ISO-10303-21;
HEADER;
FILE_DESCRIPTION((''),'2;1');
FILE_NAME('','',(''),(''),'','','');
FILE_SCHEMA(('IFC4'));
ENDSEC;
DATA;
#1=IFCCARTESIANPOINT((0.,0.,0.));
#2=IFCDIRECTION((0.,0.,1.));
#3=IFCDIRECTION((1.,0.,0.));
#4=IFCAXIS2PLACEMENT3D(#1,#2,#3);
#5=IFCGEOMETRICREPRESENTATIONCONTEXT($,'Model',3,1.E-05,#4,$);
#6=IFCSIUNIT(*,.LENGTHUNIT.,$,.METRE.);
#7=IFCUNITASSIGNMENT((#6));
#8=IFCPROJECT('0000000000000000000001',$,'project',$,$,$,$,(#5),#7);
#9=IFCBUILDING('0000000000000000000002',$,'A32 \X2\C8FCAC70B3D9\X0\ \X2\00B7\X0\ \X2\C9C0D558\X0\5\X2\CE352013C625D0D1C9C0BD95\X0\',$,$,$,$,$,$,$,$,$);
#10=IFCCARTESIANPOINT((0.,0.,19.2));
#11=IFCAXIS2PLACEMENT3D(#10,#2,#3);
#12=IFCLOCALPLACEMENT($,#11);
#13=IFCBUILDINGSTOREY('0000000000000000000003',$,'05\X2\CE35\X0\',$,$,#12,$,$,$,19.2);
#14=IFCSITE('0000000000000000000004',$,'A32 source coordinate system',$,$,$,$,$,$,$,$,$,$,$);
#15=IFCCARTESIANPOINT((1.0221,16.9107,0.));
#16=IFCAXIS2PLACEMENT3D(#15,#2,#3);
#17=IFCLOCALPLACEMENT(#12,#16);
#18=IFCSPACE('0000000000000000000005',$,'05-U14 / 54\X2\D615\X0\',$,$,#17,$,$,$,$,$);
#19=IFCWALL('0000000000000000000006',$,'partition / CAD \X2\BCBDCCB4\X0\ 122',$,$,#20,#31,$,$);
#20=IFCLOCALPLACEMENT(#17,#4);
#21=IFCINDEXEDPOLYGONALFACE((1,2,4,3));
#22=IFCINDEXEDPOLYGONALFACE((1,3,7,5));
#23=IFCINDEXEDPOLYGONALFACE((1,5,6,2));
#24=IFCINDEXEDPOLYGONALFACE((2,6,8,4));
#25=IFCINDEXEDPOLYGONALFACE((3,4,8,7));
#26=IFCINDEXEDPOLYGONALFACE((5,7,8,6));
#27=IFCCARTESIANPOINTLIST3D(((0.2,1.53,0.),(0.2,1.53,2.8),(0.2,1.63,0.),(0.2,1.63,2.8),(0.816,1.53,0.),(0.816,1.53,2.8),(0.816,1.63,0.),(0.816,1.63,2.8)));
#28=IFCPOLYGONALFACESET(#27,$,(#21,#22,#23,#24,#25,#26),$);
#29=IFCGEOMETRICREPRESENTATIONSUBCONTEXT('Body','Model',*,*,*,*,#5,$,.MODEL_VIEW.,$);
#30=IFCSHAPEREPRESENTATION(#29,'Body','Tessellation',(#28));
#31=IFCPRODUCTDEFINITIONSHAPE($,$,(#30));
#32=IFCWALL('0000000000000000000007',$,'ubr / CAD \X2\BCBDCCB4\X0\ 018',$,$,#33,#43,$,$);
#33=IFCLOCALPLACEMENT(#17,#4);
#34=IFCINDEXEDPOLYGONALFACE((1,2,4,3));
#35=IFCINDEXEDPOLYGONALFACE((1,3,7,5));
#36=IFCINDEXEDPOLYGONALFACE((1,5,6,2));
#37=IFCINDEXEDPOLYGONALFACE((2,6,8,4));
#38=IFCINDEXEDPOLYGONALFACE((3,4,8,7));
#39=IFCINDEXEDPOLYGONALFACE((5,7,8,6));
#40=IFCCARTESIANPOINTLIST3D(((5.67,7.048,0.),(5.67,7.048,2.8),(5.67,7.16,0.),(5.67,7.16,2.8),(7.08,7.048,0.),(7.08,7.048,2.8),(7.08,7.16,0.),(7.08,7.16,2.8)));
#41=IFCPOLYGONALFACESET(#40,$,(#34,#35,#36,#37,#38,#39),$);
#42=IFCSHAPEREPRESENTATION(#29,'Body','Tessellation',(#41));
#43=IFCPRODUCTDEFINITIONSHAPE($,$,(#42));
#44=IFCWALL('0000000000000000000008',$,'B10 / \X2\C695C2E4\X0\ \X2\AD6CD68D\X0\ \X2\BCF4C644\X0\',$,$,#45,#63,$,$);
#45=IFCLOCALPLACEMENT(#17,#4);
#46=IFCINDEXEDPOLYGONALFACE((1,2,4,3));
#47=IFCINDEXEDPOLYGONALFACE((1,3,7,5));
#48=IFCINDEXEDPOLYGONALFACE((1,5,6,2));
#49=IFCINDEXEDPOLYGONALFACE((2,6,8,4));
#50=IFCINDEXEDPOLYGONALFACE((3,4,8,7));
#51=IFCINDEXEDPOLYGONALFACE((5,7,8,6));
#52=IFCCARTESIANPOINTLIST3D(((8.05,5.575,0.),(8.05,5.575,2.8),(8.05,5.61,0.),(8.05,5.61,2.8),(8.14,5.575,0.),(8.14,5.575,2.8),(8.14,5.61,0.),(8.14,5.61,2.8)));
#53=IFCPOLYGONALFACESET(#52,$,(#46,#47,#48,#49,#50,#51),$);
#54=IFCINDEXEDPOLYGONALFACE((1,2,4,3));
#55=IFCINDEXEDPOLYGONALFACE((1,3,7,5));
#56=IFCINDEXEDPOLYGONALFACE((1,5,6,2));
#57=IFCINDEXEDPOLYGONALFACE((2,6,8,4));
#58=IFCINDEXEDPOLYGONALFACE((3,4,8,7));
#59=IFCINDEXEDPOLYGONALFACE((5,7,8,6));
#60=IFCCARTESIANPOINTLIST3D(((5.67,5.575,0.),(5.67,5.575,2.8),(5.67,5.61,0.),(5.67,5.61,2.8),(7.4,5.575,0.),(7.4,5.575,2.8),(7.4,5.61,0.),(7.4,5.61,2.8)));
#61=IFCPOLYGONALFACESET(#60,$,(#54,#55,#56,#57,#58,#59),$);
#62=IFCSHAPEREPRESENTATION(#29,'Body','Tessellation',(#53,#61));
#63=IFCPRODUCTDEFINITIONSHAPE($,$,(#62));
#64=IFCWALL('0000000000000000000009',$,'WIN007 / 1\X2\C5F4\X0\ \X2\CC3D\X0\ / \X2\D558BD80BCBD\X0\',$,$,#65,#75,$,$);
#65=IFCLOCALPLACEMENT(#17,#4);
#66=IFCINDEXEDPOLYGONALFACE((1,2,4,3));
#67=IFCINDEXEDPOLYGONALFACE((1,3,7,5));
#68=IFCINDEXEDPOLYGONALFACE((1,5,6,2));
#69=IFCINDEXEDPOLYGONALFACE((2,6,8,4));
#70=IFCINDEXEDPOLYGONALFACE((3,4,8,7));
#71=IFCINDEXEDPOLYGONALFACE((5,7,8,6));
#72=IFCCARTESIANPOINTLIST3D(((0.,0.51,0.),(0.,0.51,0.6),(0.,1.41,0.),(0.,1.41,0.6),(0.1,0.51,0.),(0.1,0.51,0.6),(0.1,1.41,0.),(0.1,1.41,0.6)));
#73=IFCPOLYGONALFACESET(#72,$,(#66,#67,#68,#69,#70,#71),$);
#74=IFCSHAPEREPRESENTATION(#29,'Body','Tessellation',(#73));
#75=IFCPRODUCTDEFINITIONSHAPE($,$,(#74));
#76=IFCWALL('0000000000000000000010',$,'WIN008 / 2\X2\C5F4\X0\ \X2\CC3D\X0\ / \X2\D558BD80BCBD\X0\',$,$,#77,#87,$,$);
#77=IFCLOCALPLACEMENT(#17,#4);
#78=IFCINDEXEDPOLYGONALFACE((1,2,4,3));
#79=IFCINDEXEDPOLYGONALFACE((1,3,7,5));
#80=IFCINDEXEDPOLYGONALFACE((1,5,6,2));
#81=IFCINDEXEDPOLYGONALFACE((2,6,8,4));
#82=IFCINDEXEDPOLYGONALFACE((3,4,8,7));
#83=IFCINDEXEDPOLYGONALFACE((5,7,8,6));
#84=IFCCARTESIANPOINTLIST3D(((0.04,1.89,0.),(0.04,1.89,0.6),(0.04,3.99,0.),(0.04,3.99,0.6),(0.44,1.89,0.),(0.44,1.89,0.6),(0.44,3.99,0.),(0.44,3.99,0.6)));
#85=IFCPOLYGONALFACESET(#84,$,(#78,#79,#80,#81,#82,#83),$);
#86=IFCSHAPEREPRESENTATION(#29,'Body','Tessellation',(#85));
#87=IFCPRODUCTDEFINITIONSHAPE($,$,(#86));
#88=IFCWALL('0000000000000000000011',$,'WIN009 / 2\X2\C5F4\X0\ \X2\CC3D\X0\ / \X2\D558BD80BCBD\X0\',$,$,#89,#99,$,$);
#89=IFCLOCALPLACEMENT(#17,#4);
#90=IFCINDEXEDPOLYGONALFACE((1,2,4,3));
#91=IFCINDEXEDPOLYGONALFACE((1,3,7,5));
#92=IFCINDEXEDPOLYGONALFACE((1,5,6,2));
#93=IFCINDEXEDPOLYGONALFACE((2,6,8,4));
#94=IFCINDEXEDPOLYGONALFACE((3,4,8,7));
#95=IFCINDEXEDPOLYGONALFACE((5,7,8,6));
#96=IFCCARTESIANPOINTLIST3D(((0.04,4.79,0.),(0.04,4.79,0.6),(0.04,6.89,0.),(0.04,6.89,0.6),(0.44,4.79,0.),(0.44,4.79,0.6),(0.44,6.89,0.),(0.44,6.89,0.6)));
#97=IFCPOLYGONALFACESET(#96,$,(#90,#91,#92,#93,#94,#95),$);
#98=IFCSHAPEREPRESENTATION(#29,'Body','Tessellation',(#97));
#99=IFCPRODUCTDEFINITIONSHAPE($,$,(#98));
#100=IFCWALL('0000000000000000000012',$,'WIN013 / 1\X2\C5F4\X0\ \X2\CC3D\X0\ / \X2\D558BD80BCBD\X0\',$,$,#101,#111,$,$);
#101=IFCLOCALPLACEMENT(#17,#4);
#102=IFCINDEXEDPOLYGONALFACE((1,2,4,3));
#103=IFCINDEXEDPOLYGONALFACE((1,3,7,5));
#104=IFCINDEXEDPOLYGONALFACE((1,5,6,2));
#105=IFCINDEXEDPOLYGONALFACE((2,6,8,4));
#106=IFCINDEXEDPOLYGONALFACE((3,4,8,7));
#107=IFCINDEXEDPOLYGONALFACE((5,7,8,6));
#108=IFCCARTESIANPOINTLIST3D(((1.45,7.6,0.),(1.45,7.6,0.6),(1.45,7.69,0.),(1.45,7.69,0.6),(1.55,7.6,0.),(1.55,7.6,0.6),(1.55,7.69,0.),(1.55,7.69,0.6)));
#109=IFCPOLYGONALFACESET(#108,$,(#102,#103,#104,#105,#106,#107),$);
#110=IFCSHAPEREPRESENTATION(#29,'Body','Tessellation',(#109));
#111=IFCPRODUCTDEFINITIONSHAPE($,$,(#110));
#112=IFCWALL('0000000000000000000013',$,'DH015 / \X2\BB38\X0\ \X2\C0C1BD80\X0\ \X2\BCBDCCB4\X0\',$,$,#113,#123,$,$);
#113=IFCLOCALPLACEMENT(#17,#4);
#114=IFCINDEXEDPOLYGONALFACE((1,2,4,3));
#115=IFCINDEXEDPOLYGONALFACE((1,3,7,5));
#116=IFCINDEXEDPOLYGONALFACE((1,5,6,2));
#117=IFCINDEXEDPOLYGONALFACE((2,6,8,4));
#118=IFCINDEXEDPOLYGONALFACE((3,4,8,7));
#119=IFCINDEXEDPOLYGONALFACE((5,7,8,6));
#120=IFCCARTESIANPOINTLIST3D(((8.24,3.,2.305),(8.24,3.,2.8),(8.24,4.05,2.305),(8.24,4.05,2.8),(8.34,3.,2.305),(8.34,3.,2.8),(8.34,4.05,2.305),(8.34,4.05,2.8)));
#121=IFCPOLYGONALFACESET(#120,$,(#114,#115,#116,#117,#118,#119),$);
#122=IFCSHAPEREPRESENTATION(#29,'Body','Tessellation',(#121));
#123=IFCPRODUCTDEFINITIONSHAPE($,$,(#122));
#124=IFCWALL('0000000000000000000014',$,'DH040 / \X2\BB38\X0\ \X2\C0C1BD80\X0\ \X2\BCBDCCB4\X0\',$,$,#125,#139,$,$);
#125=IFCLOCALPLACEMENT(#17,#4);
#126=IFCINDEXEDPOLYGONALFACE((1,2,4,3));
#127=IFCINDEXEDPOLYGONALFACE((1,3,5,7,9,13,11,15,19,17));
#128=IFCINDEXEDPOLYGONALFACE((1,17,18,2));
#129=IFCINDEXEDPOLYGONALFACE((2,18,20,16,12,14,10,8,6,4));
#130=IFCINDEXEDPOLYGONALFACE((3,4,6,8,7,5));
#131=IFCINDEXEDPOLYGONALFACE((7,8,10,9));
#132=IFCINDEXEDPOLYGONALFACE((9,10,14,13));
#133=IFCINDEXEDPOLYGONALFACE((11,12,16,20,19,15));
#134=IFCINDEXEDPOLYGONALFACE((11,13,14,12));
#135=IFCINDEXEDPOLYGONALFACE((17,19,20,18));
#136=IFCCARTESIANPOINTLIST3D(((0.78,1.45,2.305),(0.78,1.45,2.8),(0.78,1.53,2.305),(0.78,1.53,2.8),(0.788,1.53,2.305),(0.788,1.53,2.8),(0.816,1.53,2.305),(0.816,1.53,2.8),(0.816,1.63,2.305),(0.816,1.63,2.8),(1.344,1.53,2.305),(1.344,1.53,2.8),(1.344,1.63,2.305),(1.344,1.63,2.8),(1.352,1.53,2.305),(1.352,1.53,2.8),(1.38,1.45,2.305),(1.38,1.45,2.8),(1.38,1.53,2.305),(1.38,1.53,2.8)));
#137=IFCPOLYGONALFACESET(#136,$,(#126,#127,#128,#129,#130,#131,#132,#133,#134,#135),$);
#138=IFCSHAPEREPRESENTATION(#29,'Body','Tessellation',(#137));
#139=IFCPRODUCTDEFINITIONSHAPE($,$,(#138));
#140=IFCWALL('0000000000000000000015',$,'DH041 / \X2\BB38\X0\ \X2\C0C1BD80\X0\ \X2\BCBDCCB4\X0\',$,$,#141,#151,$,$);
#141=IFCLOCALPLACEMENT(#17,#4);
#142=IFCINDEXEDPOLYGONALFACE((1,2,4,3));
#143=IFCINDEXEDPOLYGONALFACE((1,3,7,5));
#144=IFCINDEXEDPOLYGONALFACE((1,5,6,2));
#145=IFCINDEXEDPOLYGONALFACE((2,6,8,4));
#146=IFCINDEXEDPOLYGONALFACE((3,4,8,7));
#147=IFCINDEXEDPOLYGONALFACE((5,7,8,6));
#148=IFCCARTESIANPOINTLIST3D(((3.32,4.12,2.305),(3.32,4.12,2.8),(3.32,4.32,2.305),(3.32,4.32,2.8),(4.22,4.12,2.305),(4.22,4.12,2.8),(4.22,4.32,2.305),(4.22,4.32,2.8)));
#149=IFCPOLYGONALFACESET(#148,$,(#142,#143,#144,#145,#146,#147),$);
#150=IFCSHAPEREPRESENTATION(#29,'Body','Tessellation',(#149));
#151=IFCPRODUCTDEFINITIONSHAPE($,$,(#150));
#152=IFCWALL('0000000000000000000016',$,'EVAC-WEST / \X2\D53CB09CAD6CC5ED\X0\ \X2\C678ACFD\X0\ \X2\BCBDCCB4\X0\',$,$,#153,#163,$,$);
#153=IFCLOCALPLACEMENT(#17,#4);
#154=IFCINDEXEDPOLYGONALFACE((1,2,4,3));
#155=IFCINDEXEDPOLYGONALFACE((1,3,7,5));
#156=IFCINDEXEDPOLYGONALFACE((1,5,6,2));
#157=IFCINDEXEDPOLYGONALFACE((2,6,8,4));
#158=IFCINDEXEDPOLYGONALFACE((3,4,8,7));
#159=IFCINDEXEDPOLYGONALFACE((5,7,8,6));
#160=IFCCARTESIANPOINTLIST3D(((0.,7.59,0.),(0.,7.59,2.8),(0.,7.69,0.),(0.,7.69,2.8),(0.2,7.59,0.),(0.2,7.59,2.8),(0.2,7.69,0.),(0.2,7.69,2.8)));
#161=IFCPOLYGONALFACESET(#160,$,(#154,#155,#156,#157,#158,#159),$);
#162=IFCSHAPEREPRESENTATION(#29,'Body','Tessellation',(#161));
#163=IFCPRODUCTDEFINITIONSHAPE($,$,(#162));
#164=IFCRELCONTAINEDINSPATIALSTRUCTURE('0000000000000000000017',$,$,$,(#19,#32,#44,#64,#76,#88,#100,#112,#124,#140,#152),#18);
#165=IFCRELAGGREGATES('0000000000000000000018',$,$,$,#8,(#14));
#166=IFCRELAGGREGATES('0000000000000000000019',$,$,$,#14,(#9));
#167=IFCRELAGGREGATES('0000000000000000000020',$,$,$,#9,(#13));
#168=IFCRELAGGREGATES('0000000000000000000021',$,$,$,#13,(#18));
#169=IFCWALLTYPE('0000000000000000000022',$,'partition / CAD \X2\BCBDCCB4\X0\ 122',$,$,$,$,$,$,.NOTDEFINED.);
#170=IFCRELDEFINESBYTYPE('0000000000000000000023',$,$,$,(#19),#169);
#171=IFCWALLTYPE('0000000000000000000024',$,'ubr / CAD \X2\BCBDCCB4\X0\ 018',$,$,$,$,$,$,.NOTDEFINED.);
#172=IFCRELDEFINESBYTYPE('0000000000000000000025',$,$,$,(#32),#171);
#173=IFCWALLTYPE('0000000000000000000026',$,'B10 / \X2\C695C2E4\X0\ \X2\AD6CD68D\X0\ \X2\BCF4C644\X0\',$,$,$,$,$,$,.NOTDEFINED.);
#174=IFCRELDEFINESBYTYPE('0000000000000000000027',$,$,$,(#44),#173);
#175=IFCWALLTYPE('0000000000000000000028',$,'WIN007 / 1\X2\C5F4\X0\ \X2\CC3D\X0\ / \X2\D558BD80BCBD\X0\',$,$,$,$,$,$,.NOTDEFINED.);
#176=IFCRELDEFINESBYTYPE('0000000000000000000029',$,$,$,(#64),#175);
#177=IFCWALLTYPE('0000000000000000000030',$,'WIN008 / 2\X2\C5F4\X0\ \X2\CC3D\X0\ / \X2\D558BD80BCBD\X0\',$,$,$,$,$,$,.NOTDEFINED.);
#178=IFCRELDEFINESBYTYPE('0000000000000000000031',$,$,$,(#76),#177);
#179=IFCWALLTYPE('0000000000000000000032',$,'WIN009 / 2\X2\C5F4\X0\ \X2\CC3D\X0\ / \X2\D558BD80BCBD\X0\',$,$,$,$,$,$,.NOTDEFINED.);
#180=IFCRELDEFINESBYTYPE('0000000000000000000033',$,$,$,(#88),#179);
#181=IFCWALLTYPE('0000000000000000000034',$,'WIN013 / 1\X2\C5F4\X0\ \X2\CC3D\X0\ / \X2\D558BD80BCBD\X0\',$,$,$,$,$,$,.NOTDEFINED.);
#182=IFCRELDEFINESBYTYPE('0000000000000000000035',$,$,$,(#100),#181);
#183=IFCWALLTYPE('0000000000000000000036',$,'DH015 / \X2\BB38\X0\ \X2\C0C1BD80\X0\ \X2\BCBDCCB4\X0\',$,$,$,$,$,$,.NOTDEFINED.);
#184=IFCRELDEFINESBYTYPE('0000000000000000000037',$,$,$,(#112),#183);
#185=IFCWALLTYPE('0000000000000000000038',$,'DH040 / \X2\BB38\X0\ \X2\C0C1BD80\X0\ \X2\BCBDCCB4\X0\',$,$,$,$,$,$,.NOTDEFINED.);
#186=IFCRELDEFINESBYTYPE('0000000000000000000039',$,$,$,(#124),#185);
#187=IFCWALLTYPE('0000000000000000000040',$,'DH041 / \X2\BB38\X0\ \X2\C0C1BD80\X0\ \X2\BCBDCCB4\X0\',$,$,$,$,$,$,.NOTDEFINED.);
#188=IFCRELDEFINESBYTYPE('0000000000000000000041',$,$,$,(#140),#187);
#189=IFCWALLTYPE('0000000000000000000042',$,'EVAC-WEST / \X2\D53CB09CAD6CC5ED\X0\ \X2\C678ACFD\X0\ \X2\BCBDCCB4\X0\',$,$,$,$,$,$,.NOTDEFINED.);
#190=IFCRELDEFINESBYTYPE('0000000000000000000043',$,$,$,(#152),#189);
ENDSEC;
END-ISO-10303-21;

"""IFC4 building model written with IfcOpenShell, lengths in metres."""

from ifc_helpers import new_model, si_unit, frame, origin, origin_with_axes, place, context, subcontext, project, spatial, polyline, outline, extrude, source, transform, mapped, type_object, type_shapes, element, save


model = new_model("IFC4")

# Units and contexts
model_context = context("Model", 3, precision=1e-05, world=origin_with_axes())
body_context = subcontext(model_context, "Body", "Model", "MODEL_VIEW")
ifc_project = project(units=[si_unit("LENGTHUNIT", "METRE")], contexts=[model_context])

# Site, building, storey, space
site = spatial("IfcSite", under=ifc_project, Name="A32 source coordinate system")
building = spatial("IfcBuilding", under=site, Name="A32 주거동 · 지하5층–옥탑지붕")
storey_placement = place(None, frame((0.0, 0.0, 19.2), z_axis=(0.0, 0.0, 1.0), x_axis=(1.0, 0.0, 0.0)))
storey = spatial("IfcBuildingStorey", under=building, at=storey_placement, Name="05층", Elevation=19.2)
space_placement = place(storey_placement, frame((1.0221, 16.9107, 0.0), z_axis=(0.0, 0.0, 1.0), x_axis=(1.0, 0.0, 0.0)))
space = spatial("IfcSpace", under=storey, at=space_placement, Name="05-U14 / 54형")

# Walls
wall_type_1 = type_object("IfcWallType", Name="partition / CAD 벽체 122", PredefinedType="NOTDEFINED")
shared_shape_1 = source(origin(), body_context, "Body", "SweptSolid", [
    extrude(outline(polyline([(0.816, 1.63), (0.816, 1.53), (0.2, 1.53), (0.2, 1.63), (0.816, 1.63)])), origin(), (0.0, 0.0, 1.0), 2.8),
])
type_shapes(wall_type_1, [shared_shape_1])
wall_1_placement = place(space_placement, origin_with_axes())
element("IfcWall", 1, at=wall_1_placement, inside=space, type_object=wall_type_1, Name="partition / CAD 벽체 122", context=body_context, shape_type="MappedRepresentation", body=[
    mapped(shared_shape_1, transform((0.0, 0.0, 0.0), scale=1.0)),
])
wall_type_2 = type_object("IfcWallType", Name="ubr / CAD 벽체 018", PredefinedType="NOTDEFINED")
shared_shape_2 = source(origin(), body_context, "Body", "SweptSolid", [
    extrude(outline(polyline([(5.67, 7.16), (7.08, 7.16), (7.08, 7.048), (5.67, 7.048), (5.67, 7.16)])), origin(), (0.0, 0.0, 1.0), 2.8),
])
type_shapes(wall_type_2, [shared_shape_2])
wall_2_placement = place(space_placement, origin_with_axes())
element("IfcWall", 2, at=wall_2_placement, inside=space, type_object=wall_type_2, Name="ubr / CAD 벽체 018", context=body_context, shape_type="MappedRepresentation", body=[
    mapped(shared_shape_2, transform((0.0, 0.0, 0.0), scale=1.0)),
])
wall_type_3 = type_object("IfcWallType", Name="B10 / 욕실 구획 보완", PredefinedType="NOTDEFINED")
shared_shape_3 = source(origin(), body_context, "Body", "SweptSolid", [
    extrude(outline(polyline([(8.14, 5.575), (8.05, 5.575), (8.05, 5.61), (8.14, 5.61), (8.14, 5.575)])), origin(), (0.0, 0.0, 1.0), 2.8),
    extrude(outline(polyline([(7.4, 5.575), (5.67, 5.575), (5.67, 5.61), (7.4, 5.61), (7.4, 5.575)])), origin(), (0.0, 0.0, 1.0), 2.8),
])
type_shapes(wall_type_3, [shared_shape_3])
wall_3_placement = place(space_placement, origin_with_axes())
element("IfcWall", 3, at=wall_3_placement, inside=space, type_object=wall_type_3, Name="B10 / 욕실 구획 보완", context=body_context, shape_type="MappedRepresentation", body=[
    mapped(shared_shape_3, transform((0.0, 0.0, 0.0), scale=1.0)),
])
wall_type_4 = type_object("IfcWallType", Name="WIN007 / 1열 창 / 하부벽", PredefinedType="NOTDEFINED")
shared_shape_4 = source(origin(), body_context, "Body", "SweptSolid", [
    extrude(outline(polyline([(0.1, 1.41), (0.1, 0.51), (0.0, 0.51), (0.0, 1.41), (0.1, 1.41)])), origin(), (0.0, 0.0, 1.0), 0.6),
])
type_shapes(wall_type_4, [shared_shape_4])
wall_4_placement = place(space_placement, origin_with_axes())
element("IfcWall", 4, at=wall_4_placement, inside=space, type_object=wall_type_4, Name="WIN007 / 1열 창 / 하부벽", context=body_context, shape_type="MappedRepresentation", body=[
    mapped(shared_shape_4, transform((0.0, 0.0, 0.0), scale=1.0)),
])
wall_type_5 = type_object("IfcWallType", Name="WIN008 / 2열 창 / 하부벽", PredefinedType="NOTDEFINED")
shared_shape_5 = source(origin(), body_context, "Body", "SweptSolid", [
    extrude(outline(polyline([(0.44, 3.99), (0.44, 1.89), (0.04, 1.89), (0.04, 3.99), (0.44, 3.99)])), origin(), (0.0, 0.0, 1.0), 0.6),
])
type_shapes(wall_type_5, [shared_shape_5])
wall_5_placement = place(space_placement, origin_with_axes())
element("IfcWall", 5, at=wall_5_placement, inside=space, type_object=wall_type_5, Name="WIN008 / 2열 창 / 하부벽", context=body_context, shape_type="MappedRepresentation", body=[
    mapped(shared_shape_5, transform((0.0, 0.0, 0.0), scale=1.0)),
])
wall_type_6 = type_object("IfcWallType", Name="WIN009 / 2열 창 / 하부벽", PredefinedType="NOTDEFINED")
shared_shape_6 = source(origin(), body_context, "Body", "SweptSolid", [
    extrude(outline(polyline([(0.44, 6.89), (0.44, 4.79), (0.04, 4.79), (0.04, 6.89), (0.44, 6.89)])), origin(), (0.0, 0.0, 1.0), 0.6),
])
type_shapes(wall_type_6, [shared_shape_6])
wall_6_placement = place(space_placement, origin_with_axes())
element("IfcWall", 6, at=wall_6_placement, inside=space, type_object=wall_type_6, Name="WIN009 / 2열 창 / 하부벽", context=body_context, shape_type="MappedRepresentation", body=[
    mapped(shared_shape_6, transform((0.0, 0.0, 0.0), scale=1.0)),
])
wall_type_7 = type_object("IfcWallType", Name="WIN013 / 1열 창 / 하부벽", PredefinedType="NOTDEFINED")
shared_shape_7 = source(origin(), body_context, "Body", "SweptSolid", [
    extrude(outline(polyline([(1.55, 7.6), (1.45, 7.6), (1.45, 7.69), (1.55, 7.69), (1.55, 7.6)])), origin(), (0.0, 0.0, 1.0), 0.6),
])
type_shapes(wall_type_7, [shared_shape_7])
wall_7_placement = place(space_placement, origin_with_axes())
element("IfcWall", 7, at=wall_7_placement, inside=space, type_object=wall_type_7, Name="WIN013 / 1열 창 / 하부벽", context=body_context, shape_type="MappedRepresentation", body=[
    mapped(shared_shape_7, transform((0.0, 0.0, 0.0), scale=1.0)),
])
wall_type_8 = type_object("IfcWallType", Name="DH015 / 문 상부 벽체", PredefinedType="NOTDEFINED")
shared_shape_8 = source(origin(), body_context, "Body", "SweptSolid", [
    extrude(outline(polyline([(8.34, 3.0), (8.24, 3.0), (8.24, 4.05), (8.34, 4.05), (8.34, 3.0)])), frame((0.0, 0.0, 2.305)), (0.0, 0.0, 1.0), 0.495),
])
type_shapes(wall_type_8, [shared_shape_8])
wall_8_placement = place(space_placement, origin_with_axes())
element("IfcWall", 8, at=wall_8_placement, inside=space, type_object=wall_type_8, Name="DH015 / 문 상부 벽체", context=body_context, shape_type="MappedRepresentation", body=[
    mapped(shared_shape_8, transform((0.0, 0.0, 0.0), scale=1.0)),
])
wall_type_9 = type_object("IfcWallType", Name="DH040 / 문 상부 벽체", PredefinedType="NOTDEFINED")
shared_shape_9 = source(origin(), body_context, "Body", "SweptSolid", [
    extrude(outline(polyline([(0.816, 1.63), (1.344, 1.63), (1.344, 1.53), (1.352, 1.53), (1.38, 1.53), (1.38, 1.45), (0.78, 1.45), (0.78, 1.53), (0.788, 1.53), (0.816, 1.53), (0.816, 1.63)])), frame((0.0, 0.0, 2.305)), (0.0, 0.0, 1.0), 0.495),
])
type_shapes(wall_type_9, [shared_shape_9])
wall_9_placement = place(space_placement, origin_with_axes())
element("IfcWall", 9, at=wall_9_placement, inside=space, type_object=wall_type_9, Name="DH040 / 문 상부 벽체", context=body_context, shape_type="MappedRepresentation", body=[
    mapped(shared_shape_9, transform((0.0, 0.0, 0.0), scale=1.0)),
])
wall_type_10 = type_object("IfcWallType", Name="DH041 / 문 상부 벽체", PredefinedType="NOTDEFINED")
shared_shape_10 = source(origin(), body_context, "Body", "SweptSolid", [
    extrude(outline(polyline([(4.22, 4.12), (3.32, 4.12), (3.32, 4.32), (4.22, 4.32), (4.22, 4.12)])), frame((0.0, 0.0, 2.305)), (0.0, 0.0, 1.0), 0.495),
])
type_shapes(wall_type_10, [shared_shape_10])
wall_10_placement = place(space_placement, origin_with_axes())
element("IfcWall", 10, at=wall_10_placement, inside=space, type_object=wall_type_10, Name="DH041 / 문 상부 벽체", context=body_context, shape_type="MappedRepresentation", body=[
    mapped(shared_shape_10, transform((0.0, 0.0, 0.0), scale=1.0)),
])
wall_type_11 = type_object("IfcWallType", Name="EVAC-WEST / 피난구역 외곽 벽체", PredefinedType="NOTDEFINED")
shared_shape_11 = source(origin(), body_context, "Body", "SweptSolid", [
    extrude(outline(polyline([(0.2, 7.59), (0.0, 7.59), (0.0, 7.69), (0.2, 7.69), (0.2, 7.59)])), origin(), (0.0, 0.0, 1.0), 2.8),
])
type_shapes(wall_type_11, [shared_shape_11])
wall_11_placement = place(space_placement, origin_with_axes())
element("IfcWall", 11, at=wall_11_placement, inside=space, type_object=wall_type_11, Name="EVAC-WEST / 피난구역 외곽 벽체", context=body_context, shape_type="MappedRepresentation", body=[
    mapped(shared_shape_11, transform((0.0, 0.0, 0.0), scale=1.0)),
])

save(model, "model.ifc")
